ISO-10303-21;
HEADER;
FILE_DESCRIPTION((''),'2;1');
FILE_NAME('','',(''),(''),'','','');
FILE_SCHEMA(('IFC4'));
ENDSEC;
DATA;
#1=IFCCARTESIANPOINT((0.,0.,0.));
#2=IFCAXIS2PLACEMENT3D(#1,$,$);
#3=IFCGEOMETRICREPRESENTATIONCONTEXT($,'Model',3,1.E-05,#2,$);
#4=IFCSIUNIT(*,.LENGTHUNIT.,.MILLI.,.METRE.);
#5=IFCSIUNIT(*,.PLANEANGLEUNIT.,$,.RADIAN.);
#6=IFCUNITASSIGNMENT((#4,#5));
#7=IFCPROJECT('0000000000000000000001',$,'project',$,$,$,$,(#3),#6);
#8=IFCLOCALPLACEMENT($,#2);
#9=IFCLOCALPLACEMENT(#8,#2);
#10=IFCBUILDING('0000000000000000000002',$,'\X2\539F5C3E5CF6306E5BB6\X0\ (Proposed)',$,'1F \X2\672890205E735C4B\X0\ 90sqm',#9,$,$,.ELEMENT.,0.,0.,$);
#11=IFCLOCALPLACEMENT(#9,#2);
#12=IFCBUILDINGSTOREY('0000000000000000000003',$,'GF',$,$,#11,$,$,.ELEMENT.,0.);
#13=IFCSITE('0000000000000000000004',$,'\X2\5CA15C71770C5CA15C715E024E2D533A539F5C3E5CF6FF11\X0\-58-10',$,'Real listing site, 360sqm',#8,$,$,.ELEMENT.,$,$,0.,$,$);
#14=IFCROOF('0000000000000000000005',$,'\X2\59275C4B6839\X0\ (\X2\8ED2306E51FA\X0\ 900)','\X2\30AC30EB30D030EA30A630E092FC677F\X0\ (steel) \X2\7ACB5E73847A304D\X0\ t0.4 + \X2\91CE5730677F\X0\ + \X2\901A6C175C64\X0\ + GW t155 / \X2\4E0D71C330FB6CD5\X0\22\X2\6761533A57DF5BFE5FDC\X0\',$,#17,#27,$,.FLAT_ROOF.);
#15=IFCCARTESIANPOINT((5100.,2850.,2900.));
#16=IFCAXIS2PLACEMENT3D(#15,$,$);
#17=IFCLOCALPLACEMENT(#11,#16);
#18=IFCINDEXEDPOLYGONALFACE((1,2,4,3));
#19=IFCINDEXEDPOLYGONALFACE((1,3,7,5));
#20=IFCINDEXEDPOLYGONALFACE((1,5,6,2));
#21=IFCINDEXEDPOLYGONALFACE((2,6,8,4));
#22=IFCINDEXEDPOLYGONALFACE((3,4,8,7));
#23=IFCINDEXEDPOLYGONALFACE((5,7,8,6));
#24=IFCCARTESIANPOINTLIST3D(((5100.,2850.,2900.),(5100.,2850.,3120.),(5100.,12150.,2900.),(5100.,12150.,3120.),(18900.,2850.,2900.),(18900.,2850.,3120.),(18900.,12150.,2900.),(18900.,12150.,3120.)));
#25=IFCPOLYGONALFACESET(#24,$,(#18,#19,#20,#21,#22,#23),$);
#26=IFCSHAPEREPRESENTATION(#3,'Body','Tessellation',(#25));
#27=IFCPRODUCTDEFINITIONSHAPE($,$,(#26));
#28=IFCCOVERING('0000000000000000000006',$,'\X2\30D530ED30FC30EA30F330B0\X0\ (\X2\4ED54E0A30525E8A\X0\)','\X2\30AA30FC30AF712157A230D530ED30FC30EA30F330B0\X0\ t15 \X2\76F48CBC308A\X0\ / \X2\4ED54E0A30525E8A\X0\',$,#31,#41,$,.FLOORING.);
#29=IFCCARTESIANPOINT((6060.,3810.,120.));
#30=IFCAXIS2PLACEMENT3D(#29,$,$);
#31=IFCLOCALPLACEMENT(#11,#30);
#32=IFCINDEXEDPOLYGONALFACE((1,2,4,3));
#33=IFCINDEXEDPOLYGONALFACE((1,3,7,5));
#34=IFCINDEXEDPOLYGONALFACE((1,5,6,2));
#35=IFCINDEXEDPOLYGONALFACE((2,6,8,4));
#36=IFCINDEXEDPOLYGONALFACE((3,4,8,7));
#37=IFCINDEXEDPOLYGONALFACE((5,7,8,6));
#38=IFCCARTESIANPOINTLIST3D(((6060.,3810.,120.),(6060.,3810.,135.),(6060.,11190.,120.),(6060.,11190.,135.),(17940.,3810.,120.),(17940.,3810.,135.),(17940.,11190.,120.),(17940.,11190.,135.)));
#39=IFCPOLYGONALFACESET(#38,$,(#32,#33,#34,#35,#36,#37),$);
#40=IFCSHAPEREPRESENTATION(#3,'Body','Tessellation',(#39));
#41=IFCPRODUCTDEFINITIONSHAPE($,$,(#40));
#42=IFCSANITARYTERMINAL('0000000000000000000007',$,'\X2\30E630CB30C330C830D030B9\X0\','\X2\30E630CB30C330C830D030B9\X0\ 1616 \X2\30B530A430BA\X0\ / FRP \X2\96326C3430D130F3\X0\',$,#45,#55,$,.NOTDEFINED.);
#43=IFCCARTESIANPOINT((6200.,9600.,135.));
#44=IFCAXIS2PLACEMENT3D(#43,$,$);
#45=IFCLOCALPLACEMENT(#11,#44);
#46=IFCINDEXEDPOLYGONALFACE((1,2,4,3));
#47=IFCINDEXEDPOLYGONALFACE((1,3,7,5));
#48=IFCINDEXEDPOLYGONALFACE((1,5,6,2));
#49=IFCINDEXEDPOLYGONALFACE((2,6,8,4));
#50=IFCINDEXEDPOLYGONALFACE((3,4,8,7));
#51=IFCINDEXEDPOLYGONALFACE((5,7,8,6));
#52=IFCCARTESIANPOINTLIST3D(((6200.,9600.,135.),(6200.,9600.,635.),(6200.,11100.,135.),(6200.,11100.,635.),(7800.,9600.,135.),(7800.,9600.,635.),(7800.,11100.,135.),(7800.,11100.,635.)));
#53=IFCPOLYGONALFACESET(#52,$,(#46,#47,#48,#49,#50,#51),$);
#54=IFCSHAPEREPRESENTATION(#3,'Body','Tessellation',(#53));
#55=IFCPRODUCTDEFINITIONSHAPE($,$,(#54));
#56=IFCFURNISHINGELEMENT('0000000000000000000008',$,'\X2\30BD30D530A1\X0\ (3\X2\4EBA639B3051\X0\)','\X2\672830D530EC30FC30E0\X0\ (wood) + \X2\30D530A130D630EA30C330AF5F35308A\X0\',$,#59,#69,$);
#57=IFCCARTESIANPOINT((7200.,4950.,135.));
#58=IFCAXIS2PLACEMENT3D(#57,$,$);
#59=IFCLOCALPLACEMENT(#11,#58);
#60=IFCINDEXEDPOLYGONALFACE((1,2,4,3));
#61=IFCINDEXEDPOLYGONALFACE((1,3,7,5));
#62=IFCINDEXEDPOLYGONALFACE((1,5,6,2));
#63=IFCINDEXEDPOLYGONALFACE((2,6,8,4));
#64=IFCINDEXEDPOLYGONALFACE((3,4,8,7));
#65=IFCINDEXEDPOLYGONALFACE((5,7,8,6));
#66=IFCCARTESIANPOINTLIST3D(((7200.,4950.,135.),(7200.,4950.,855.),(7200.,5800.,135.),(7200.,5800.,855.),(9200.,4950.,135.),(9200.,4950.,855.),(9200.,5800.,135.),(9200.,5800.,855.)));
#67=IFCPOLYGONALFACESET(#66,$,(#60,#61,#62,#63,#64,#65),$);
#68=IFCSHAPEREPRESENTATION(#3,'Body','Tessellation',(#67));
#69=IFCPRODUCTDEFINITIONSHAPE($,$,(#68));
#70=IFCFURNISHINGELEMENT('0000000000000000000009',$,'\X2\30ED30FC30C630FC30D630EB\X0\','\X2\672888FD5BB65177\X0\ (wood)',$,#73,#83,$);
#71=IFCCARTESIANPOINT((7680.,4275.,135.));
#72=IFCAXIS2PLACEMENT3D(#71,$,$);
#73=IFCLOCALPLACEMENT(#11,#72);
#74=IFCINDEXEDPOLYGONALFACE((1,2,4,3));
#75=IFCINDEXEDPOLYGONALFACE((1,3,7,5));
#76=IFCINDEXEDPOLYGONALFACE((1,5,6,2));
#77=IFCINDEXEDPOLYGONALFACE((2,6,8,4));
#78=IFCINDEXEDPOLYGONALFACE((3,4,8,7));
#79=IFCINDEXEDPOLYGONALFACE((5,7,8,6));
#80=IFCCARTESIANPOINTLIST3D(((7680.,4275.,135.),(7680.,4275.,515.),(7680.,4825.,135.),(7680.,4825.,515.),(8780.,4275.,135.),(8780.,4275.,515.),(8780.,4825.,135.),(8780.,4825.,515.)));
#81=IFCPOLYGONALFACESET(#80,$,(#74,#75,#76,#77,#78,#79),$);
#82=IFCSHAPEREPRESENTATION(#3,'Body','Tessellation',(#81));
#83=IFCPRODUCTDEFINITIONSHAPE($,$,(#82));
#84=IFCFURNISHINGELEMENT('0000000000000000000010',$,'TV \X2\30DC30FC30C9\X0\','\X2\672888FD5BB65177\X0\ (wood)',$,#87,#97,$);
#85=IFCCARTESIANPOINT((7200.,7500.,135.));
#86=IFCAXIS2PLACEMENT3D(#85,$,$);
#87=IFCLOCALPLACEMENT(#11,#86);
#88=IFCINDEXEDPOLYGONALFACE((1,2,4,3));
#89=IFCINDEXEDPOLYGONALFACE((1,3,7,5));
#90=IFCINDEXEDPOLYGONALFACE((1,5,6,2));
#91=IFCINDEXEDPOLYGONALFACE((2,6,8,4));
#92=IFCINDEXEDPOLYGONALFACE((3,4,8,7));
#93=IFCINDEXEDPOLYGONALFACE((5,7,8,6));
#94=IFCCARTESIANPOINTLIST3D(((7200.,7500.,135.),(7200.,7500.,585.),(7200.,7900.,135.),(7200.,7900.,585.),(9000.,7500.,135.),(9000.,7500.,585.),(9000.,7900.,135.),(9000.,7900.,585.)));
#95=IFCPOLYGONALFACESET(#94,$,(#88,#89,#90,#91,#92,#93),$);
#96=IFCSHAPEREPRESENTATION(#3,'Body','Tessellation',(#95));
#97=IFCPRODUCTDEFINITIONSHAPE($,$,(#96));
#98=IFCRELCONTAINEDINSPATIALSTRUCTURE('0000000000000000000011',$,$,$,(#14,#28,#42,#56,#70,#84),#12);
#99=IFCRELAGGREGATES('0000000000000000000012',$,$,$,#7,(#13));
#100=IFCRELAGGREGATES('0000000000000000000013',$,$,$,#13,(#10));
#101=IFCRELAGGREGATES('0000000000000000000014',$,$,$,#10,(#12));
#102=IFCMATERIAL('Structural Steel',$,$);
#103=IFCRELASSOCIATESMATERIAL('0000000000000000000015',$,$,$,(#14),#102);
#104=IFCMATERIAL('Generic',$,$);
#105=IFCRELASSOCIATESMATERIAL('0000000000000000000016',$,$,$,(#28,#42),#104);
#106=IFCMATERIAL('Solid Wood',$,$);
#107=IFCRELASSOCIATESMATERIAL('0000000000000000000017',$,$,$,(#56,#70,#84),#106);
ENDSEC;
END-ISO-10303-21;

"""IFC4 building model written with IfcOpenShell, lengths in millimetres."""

from ifc_helpers import new_model, si_unit, frame, frame_2d, origin, place, context, project, spatial, rectangle, extrude, material, element, save


model = new_model("IFC4")

# Units and contexts
model_context = context("Model", 3, precision=1e-05, world=origin())
ifc_project = project(units=[si_unit("LENGTHUNIT", "METRE", prefix="MILLI"), si_unit("PLANEANGLEUNIT", "RADIAN")], contexts=[model_context])

# Site, building, storey
site_placement = place(None, origin())
site = spatial("IfcSite", under=ifc_project, at=site_placement, Name="岡山県岡山市中区原尾島１-58-10", ObjectType="Real listing site, 360sqm", CompositionType="ELEMENT", RefElevation=0.0)
building_placement = place(site_placement, origin())
building = spatial("IfcBuilding", under=site, at=building_placement, Name="原尾島の家 (Proposed)", ObjectType="1F 木造平屋 90sqm", CompositionType="ELEMENT", ElevationOfRefHeight=0.0, ElevationOfTerrain=0.0)
storey_placement = place(building_placement, origin())
storey = spatial("IfcBuildingStorey", under=building, at=storey_placement, Name="GF", CompositionType="ELEMENT", Elevation=0.0)

# Shared definitions
ifc_material_1 = material(Name="Solid Wood")

# Roof
ifc_material_2 = material(Name="Structural Steel")
roof_placement = place(storey_placement, frame((5100.0, 2850.0, 2900.0)))
element("IfcRoof", 1, at=roof_placement, inside=storey, material=ifc_material_2, Name="大屋根 (軒の出 900)", Description="ガルバリウム鋼板 (steel) 立平葺き t0.4 + 野地板 + 通気層 + GW t155 / 不燃・法22条区域対応", PredefinedType="FLAT_ROOF", context=model_context, shape_type="SweptSolid", body=[
    extrude(rectangle(XDim=13800.0, YDim=9300.0, at=frame_2d((6900.0, 4650.0))), frame((5100.0, 2850.0, 2900.0)), (0.0, 0.0, 1.0), 220.0),
])

# Covering
ifc_material_3 = material(Name="Generic")
covering_placement = place(storey_placement, frame((6060.0, 3810.0, 120.0)))
element("IfcCovering", 2, at=covering_placement, inside=storey, material=ifc_material_3, Name="フローリング (仕上げ床)", Description="オーク無垢フローリング t15 直貼り / 仕上げ床", PredefinedType="FLOORING", context=model_context, shape_type="SweptSolid", body=[
    extrude(rectangle(XDim=11880.0, YDim=7380.0, at=frame_2d((5940.0, 3690.0))), frame((6060.0, 3810.0, 120.0)), (0.0, 0.0, 1.0), 15.0),
])

# Sanitary terminal
sanitary_terminal_placement = place(storey_placement, frame((6200.0, 9600.0, 135.0)))
element("IfcSanitaryTerminal", 3, at=sanitary_terminal_placement, inside=storey, material=ifc_material_3, Name="ユニットバス", Description="ユニットバス 1616 サイズ / FRP 防水パン", PredefinedType="NOTDEFINED", context=model_context, shape_type="SweptSolid", body=[
    extrude(rectangle(XDim=1600.0, YDim=1500.0, at=frame_2d((800.0, 750.0))), frame((6200.0, 9600.0, 135.0)), (0.0, 0.0, 1.0), 500.0),
])

# Furnishing elements
furnishing_1_placement = place(storey_placement, frame((7200.0, 4950.0, 135.0)))
element("IfcFurnishingElement", 4, at=furnishing_1_placement, inside=storey, material=ifc_material_1, Name="ソファ (3人掛け)", Description="木フレーム (wood) + ファブリック張り", context=model_context, shape_type="SweptSolid", body=[
    extrude(rectangle(XDim=2000.0, YDim=850.0, at=frame_2d((1000.0, 425.0))), frame((7200.0, 4950.0, 135.0)), (0.0, 0.0, 1.0), 720.0),
])
furnishing_2_placement = place(storey_placement, frame((7680.0, 4275.0, 135.0)))
element("IfcFurnishingElement", 5, at=furnishing_2_placement, inside=storey, material=ifc_material_1, Name="ローテーブル", Description="木製家具 (wood)", context=model_context, shape_type="SweptSolid", body=[
    extrude(rectangle(XDim=1100.0, YDim=550.0, at=frame_2d((550.0, 275.0))), frame((7680.0, 4275.0, 135.0)), (0.0, 0.0, 1.0), 380.0),
])
furnishing_3_placement = place(storey_placement, frame((7200.0, 7500.0, 135.0)))
element("IfcFurnishingElement", 6, at=furnishing_3_placement, inside=storey, material=ifc_material_1, Name="TV ボード", Description="木製家具 (wood)", context=model_context, shape_type="SweptSolid", body=[
    extrude(rectangle(XDim=1800.0, YDim=400.0, at=frame_2d((900.0, 200.0))), frame((7200.0, 7500.0, 135.0)), (0.0, 0.0, 1.0), 450.0),
])

save(model, "model.ifc")
